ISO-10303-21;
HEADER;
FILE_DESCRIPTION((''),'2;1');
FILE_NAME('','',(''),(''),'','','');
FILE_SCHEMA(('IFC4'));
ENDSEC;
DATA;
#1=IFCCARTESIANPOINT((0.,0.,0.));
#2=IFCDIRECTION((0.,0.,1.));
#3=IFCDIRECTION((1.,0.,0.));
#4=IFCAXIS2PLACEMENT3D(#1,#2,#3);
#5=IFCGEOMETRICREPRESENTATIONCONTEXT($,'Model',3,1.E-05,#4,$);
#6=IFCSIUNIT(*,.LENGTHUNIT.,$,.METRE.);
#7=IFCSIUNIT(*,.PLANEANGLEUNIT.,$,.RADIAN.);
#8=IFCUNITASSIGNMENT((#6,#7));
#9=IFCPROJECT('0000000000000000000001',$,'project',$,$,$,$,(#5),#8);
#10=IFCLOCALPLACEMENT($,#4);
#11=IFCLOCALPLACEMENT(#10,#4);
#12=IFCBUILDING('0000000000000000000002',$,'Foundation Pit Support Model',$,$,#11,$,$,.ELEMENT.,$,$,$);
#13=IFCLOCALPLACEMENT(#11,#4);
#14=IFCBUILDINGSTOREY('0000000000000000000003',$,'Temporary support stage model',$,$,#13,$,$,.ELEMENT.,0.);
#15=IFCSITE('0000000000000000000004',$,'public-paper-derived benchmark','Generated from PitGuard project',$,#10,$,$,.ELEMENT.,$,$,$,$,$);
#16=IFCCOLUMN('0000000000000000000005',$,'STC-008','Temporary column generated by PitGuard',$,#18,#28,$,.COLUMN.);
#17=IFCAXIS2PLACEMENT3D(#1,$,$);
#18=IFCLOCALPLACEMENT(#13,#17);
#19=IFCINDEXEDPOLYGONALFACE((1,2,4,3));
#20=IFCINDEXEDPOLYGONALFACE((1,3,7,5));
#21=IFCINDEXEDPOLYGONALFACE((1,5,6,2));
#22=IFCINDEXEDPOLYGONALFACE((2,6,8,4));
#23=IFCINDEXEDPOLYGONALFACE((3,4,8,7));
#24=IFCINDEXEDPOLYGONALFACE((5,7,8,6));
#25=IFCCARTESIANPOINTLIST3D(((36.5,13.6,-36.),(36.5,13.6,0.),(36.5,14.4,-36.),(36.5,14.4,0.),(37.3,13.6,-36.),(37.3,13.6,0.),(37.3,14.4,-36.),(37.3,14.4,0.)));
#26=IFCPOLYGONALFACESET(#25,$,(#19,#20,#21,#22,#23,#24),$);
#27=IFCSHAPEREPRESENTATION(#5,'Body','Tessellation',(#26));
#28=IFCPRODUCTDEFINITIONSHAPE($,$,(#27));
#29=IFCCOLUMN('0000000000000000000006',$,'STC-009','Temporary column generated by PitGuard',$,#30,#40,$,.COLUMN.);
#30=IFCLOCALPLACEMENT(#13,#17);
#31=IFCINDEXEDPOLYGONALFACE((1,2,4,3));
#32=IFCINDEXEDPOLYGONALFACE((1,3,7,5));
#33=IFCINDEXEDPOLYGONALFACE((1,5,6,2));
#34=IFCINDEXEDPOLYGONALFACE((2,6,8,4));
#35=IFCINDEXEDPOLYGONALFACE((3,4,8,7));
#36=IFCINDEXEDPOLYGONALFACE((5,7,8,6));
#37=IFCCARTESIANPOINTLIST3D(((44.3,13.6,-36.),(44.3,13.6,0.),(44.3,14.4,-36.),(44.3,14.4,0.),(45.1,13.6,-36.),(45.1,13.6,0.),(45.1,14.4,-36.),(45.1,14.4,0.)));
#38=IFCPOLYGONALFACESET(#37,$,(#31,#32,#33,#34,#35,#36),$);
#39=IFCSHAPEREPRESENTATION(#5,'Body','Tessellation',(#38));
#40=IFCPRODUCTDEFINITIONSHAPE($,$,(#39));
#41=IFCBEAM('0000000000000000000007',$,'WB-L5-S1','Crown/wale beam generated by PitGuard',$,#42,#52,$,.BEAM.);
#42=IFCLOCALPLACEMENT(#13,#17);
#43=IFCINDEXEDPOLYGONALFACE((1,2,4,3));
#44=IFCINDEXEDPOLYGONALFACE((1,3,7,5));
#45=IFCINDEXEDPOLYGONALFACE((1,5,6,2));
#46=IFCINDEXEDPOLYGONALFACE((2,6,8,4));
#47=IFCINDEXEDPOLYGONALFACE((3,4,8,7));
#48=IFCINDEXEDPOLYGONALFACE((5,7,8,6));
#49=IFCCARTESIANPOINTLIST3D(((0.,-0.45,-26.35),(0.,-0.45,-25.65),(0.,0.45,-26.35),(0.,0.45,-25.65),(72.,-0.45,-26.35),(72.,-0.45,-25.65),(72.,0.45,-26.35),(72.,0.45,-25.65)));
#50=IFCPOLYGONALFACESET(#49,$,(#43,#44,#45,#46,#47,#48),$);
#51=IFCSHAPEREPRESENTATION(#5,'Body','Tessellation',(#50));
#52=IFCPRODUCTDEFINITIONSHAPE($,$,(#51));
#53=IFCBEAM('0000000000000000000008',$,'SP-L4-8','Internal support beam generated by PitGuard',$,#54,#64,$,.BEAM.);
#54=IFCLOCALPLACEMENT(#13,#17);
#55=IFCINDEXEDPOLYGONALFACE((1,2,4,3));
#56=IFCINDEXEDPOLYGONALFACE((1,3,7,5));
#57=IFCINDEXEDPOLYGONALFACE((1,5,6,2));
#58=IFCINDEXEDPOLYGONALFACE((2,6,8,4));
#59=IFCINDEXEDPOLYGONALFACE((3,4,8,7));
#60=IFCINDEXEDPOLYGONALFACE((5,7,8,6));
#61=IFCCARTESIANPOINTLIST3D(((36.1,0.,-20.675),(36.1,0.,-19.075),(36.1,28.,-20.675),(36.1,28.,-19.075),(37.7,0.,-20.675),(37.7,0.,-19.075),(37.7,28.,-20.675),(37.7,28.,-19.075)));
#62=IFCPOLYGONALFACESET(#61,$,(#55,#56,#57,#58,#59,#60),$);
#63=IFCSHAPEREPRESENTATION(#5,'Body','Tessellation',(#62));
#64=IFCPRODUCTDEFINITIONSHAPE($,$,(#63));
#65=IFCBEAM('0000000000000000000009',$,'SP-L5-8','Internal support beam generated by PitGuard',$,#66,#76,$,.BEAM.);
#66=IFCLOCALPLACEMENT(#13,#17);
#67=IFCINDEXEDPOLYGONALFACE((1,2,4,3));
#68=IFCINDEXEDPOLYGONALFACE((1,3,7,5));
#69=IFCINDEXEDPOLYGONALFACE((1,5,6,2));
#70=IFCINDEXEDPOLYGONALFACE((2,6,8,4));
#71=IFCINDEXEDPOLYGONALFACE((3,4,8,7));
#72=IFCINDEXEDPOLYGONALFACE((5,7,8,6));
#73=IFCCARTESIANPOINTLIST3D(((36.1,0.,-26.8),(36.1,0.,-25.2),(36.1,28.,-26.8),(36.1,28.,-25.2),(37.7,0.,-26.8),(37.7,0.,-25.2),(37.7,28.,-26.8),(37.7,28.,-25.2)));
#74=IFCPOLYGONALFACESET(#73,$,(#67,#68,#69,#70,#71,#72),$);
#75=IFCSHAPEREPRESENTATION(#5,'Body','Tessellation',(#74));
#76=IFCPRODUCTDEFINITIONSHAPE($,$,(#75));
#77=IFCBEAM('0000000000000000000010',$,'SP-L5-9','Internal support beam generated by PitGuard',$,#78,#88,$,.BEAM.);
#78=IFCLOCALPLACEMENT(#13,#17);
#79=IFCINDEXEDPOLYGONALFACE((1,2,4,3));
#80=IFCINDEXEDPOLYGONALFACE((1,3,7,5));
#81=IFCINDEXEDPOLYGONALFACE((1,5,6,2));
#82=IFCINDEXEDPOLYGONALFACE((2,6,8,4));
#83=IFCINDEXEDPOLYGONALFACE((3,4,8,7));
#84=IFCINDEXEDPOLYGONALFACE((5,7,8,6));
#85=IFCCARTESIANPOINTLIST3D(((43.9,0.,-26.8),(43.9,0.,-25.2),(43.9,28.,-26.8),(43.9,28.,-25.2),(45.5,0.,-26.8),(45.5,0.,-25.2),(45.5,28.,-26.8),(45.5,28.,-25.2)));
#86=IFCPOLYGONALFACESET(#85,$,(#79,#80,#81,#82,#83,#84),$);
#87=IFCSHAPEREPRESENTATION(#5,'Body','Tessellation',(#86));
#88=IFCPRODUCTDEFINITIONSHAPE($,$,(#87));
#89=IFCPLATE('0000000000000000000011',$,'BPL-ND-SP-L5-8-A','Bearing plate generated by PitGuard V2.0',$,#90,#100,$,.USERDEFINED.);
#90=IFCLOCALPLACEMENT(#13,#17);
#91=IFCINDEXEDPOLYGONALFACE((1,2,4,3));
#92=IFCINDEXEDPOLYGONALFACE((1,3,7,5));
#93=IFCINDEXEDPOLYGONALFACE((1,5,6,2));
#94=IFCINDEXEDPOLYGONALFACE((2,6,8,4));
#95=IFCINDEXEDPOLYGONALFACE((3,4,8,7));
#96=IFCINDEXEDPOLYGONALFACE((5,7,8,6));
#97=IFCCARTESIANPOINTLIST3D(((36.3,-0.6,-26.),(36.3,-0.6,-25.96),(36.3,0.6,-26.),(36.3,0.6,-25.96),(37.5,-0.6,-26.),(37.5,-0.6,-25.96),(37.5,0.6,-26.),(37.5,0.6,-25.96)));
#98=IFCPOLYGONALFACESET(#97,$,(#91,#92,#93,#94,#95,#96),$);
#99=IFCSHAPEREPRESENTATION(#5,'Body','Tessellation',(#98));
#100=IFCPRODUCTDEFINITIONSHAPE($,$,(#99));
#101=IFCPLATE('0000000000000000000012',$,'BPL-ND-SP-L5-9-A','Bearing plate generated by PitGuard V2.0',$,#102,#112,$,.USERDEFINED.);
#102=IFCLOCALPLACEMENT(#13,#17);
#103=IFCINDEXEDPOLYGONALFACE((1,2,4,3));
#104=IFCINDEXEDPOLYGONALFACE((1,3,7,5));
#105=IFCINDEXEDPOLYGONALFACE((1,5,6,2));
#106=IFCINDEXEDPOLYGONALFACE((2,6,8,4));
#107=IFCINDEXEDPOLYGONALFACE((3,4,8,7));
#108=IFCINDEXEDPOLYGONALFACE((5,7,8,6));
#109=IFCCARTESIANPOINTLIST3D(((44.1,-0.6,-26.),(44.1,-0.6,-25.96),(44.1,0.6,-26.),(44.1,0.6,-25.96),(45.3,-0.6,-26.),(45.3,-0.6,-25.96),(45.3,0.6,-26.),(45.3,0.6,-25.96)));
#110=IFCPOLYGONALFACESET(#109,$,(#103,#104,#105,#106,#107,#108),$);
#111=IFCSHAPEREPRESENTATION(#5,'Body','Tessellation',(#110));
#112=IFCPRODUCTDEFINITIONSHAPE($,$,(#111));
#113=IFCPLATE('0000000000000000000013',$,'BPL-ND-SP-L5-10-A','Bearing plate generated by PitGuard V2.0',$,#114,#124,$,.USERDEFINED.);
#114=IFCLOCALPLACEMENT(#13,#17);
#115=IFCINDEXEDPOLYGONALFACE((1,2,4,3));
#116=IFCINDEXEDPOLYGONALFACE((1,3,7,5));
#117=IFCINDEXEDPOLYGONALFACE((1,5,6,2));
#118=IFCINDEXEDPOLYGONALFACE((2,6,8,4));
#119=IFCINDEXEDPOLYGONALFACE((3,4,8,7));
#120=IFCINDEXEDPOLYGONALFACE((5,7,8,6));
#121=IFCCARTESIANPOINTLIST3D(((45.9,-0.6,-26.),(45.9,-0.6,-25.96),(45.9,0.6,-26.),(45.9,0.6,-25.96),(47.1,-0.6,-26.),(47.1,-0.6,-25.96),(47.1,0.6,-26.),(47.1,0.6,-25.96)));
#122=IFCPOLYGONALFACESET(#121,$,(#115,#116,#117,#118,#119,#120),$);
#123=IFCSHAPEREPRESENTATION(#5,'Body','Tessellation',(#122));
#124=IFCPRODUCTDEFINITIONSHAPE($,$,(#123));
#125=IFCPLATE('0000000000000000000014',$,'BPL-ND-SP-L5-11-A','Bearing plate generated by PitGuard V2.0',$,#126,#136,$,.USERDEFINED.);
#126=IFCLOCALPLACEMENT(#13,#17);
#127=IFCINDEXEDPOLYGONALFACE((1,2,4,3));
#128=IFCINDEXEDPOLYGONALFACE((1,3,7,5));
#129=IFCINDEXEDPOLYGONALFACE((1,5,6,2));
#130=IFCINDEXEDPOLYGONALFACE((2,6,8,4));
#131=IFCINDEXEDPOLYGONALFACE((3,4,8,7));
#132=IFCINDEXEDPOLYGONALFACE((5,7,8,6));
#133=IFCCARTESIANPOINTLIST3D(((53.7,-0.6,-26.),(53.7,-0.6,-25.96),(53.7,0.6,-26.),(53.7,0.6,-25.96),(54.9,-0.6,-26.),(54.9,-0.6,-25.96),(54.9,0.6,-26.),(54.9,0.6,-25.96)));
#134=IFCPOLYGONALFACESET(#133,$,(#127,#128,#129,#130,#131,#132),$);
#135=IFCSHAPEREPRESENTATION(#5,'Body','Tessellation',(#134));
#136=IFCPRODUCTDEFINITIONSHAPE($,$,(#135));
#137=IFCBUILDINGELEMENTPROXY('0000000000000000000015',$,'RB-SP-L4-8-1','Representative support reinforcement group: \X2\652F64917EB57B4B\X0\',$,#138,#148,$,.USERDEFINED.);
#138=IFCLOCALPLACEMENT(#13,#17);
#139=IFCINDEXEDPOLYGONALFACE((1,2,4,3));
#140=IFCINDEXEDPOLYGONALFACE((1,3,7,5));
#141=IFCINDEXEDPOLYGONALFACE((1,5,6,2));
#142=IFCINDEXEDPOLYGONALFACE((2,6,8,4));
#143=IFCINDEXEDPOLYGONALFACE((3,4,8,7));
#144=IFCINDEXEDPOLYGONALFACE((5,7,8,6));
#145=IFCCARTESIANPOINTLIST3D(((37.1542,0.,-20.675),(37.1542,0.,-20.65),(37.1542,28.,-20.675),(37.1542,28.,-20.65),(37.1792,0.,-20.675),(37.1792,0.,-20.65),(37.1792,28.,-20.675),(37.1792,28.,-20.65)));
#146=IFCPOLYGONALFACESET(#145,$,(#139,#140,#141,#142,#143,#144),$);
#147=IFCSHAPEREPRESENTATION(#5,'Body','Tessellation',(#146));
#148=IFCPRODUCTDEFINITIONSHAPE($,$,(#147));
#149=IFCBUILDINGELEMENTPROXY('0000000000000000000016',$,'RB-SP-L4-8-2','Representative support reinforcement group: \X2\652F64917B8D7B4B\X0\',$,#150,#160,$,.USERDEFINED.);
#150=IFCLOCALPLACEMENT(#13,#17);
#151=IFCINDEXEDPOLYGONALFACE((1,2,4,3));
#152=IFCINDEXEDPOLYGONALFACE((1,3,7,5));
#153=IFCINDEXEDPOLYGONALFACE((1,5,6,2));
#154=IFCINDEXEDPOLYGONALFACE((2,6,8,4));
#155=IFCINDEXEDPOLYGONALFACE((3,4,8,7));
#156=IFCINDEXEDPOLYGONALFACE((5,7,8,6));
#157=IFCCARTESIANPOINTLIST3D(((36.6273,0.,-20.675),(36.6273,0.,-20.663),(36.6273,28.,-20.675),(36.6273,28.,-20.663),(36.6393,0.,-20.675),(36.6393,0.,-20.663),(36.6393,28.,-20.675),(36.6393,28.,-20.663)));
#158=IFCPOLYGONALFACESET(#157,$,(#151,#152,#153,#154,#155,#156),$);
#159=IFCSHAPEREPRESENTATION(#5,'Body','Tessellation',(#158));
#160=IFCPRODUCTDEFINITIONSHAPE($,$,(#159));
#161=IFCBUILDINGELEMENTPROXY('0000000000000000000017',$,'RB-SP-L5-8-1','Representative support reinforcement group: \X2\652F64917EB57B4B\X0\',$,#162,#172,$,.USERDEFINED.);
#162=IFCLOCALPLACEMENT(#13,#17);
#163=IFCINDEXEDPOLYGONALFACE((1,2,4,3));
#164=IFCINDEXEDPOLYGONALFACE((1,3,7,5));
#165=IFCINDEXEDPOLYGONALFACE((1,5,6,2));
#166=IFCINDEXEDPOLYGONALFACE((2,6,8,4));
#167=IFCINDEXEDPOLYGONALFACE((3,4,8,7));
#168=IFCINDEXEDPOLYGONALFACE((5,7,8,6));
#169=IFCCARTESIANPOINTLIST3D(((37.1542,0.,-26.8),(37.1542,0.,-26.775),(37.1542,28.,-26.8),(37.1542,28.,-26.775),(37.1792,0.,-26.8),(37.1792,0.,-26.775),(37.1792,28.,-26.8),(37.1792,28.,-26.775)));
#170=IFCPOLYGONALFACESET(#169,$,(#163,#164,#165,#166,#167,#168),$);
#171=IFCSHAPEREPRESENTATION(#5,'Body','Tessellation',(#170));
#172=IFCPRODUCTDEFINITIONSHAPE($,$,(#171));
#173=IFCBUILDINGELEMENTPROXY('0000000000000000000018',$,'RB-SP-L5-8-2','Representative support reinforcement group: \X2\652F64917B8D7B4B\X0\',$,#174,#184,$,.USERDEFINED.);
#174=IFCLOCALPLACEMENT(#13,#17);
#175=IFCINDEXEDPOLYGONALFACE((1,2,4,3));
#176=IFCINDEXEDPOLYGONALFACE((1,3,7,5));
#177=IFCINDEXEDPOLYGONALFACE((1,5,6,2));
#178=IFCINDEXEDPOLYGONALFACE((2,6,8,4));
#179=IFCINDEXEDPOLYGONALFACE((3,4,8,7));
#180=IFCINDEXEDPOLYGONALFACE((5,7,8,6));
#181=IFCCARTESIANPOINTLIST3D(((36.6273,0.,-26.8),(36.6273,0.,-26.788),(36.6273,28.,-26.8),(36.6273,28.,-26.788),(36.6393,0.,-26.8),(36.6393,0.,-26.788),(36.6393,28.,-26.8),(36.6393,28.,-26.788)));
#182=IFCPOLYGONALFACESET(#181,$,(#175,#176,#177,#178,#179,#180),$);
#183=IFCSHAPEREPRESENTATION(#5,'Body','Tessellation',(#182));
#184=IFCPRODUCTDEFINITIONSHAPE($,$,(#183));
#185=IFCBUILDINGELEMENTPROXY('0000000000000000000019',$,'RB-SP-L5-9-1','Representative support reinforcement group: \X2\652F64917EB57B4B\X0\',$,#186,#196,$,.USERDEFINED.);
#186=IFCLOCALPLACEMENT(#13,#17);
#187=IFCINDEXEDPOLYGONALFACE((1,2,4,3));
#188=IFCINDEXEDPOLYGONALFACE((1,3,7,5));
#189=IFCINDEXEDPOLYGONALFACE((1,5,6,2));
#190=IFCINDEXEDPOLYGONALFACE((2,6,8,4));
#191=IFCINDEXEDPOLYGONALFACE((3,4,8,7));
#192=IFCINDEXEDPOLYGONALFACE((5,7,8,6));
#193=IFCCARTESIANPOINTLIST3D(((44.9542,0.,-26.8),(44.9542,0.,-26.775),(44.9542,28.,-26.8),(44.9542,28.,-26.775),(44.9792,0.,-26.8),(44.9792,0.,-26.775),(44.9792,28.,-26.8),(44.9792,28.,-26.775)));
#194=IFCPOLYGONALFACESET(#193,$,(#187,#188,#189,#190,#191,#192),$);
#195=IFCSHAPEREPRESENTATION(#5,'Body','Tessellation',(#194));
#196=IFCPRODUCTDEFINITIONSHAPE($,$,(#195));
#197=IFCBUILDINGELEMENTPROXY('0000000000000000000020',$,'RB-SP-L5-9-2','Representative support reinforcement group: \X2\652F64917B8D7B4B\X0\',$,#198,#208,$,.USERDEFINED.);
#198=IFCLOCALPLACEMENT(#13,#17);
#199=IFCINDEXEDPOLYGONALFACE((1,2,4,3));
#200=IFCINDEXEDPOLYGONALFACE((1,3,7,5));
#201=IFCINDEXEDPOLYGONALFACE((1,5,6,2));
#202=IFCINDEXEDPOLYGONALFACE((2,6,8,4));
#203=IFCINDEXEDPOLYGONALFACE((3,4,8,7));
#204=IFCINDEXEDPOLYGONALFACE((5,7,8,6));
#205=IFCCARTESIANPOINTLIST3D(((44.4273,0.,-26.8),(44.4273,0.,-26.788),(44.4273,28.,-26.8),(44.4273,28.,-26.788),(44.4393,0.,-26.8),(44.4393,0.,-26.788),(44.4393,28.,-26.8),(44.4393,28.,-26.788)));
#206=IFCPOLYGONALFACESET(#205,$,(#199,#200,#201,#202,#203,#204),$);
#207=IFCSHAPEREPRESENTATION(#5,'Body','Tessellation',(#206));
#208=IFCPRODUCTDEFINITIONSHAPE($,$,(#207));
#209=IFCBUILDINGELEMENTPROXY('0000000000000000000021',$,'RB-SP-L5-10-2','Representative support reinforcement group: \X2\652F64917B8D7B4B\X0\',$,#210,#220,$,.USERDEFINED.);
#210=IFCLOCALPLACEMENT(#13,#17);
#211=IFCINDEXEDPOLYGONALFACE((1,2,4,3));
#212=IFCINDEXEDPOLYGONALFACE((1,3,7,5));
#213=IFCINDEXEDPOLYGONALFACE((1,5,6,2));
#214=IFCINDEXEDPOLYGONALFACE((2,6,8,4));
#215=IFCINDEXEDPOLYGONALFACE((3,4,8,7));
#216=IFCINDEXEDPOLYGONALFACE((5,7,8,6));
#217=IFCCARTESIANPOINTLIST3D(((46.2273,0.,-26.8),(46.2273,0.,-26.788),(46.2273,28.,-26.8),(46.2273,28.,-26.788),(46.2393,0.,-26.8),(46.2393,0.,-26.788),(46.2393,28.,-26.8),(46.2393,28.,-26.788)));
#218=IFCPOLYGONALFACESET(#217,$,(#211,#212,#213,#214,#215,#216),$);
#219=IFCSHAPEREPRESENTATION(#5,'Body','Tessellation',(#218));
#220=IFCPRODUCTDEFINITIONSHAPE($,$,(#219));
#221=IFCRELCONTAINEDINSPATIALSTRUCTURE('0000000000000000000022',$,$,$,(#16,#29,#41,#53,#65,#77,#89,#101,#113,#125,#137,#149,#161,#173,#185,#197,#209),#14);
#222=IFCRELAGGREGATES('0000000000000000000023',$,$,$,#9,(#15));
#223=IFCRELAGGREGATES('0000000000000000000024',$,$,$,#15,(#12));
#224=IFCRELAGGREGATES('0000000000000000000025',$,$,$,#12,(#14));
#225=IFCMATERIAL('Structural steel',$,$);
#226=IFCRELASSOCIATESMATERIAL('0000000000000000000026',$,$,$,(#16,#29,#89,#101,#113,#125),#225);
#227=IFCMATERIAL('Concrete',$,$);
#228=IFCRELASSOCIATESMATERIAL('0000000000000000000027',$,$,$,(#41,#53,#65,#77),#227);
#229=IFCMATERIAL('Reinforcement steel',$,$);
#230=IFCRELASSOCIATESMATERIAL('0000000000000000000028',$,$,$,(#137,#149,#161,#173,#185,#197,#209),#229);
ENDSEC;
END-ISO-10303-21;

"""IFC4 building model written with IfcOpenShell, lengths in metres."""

from ifc_helpers import new_model, si_unit, frame, origin_with_axes, origin_2d, place, context, project, spatial, rectangle, extrude, material, element, save


model = new_model("IFC4")

# Units and contexts
model_context = context("Model", 3, precision=1e-05, world=origin_with_axes())
ifc_project = project(units=[si_unit("LENGTHUNIT", "METRE"), si_unit("PLANEANGLEUNIT", "RADIAN")], contexts=[model_context])

# Site, building, storey
site_placement = place(None, origin_with_axes())
site = spatial("IfcSite", under=ifc_project, at=site_placement, Name="public-paper-derived benchmark", Description="Generated from PitGuard project", CompositionType="ELEMENT")
building_placement = place(site_placement, origin_with_axes())
building = spatial("IfcBuilding", under=site, at=building_placement, Name="Foundation Pit Support Model", CompositionType="ELEMENT")
storey_placement = place(building_placement, origin_with_axes())
storey = spatial("IfcBuildingStorey", under=building, at=storey_placement, Name="Temporary support stage model", CompositionType="ELEMENT", Elevation=0.0)

# Columns
ifc_material_1 = material(Name="Structural steel")
for number, where, z_axis, x_axis, name in (
    (1, (36.9, 14.0, -36.0), (0.0, 0.0, 1.0), (1.0, 0.0, 0.0), "STC-008"),
    (2, (44.7, 14.0, -36.0), (0.0, 0.0, 1.0), (1.0, 0.0, 0.0), "STC-009"),
):
    element("IfcColumn", number, at=place(storey_placement, frame(where, z_axis=z_axis, x_axis=x_axis)), inside=storey, material=ifc_material_1, Name=name, Description="Temporary column generated by PitGuard", PredefinedType="COLUMN", context=model_context, shape_type="SweptSolid", body=[
        extrude(rectangle(XDim=0.8, YDim=0.8, at=origin_2d()), origin_with_axes(), (0.0, 0.0, 1.0), 36.0),
    ])

# Beams
ifc_material_2 = material(Name="Concrete")
beam_placement = place(storey_placement, frame((36.0, 0.0, -26.35), z_axis=(0.0, 0.0, 1.0), x_axis=(1.0, 0.0, 0.0)))
element("IfcBeam", 3, at=beam_placement, inside=storey, material=ifc_material_2, Name="WB-L5-S1", Description="Crown/wale beam generated by PitGuard", PredefinedType="BEAM", context=model_context, shape_type="SweptSolid", body=[
    extrude(rectangle(XDim=72.0, YDim=0.9, at=origin_2d()), origin_with_axes(), (0.0, 0.0, 1.0), 0.7),
])
for number, where, z_axis, x_axis, name in (
    (4, (36.9, 14.0, -20.675), (0.0, 0.0, 1.0), (0.0, 1.0, 0.0), "SP-L4-8"),
    (5, (36.9, 14.0, -26.8), (0.0, 0.0, 1.0), (0.0, 1.0, 0.0), "SP-L5-8"),
    (6, (44.7, 14.0, -26.8), (0.0, 0.0, 1.0), (0.0, 1.0, 0.0), "SP-L5-9"),
):
    element("IfcBeam", number, at=place(storey_placement, frame(where, z_axis=z_axis, x_axis=x_axis)), inside=storey, material=ifc_material_2, Name=name, Description="Internal support beam generated by PitGuard", PredefinedType="BEAM", context=model_context, shape_type="SweptSolid", body=[
        extrude(rectangle(XDim=28.0, YDim=1.6, at=origin_2d()), origin_with_axes(), (0.0, 0.0, 1.0), 1.6),
    ])

# Plates
for number, where, z_axis, x_axis, name in (
    (7, (36.9, 0.0, -26.0), (0.0, 0.0, 1.0), (1.0, 0.0, 0.0), "BPL-ND-SP-L5-8-A"),
    (8, (44.7, 0.0, -26.0), (0.0, 0.0, 1.0), (1.0, 0.0, 0.0), "BPL-ND-SP-L5-9-A"),
    (9, (46.5, 0.0, -26.0), (0.0, 0.0, 1.0), (1.0, 0.0, 0.0), "BPL-ND-SP-L5-10-A"),
    (10, (54.3, 0.0, -26.0), (0.0, 0.0, 1.0), (1.0, 0.0, 0.0), "BPL-ND-SP-L5-11-A"),
):
    element("IfcPlate", number, at=place(storey_placement, frame(where, z_axis=z_axis, x_axis=x_axis)), inside=storey, material=ifc_material_1, Name=name, Description="Bearing plate generated by PitGuard V2.0", PredefinedType="USERDEFINED", context=model_context, shape_type="SweptSolid", body=[
        extrude(rectangle(XDim=1.2, YDim=1.2, at=origin_2d()), origin_with_axes(), (0.0, 0.0, 1.0), 0.04),
    ])

# Building element proxies
ifc_material_3 = material(Name="Reinforcement steel")
proxy_1_placement = place(storey_placement, frame((37.1667, 14.0, -20.675), z_axis=(0.0, 0.0, 1.0), x_axis=(0.0, 1.0, 0.0)))
element("IfcBuildingElementProxy", 11, at=proxy_1_placement, inside=storey, material=ifc_material_3, Name="RB-SP-L4-8-1", Description="Representative support reinforcement group: 支撑纵筋", PredefinedType="USERDEFINED", context=model_context, shape_type="SweptSolid", body=[
    extrude(rectangle(XDim=28.0, YDim=0.025, at=origin_2d()), origin_with_axes(), (0.0, 0.0, 1.0), 0.025),
])
proxy_2_placement = place(storey_placement, frame((36.6333, 14.0, -20.675), z_axis=(0.0, 0.0, 1.0), x_axis=(0.0, 1.0, 0.0)))
element("IfcBuildingElementProxy", 12, at=proxy_2_placement, inside=storey, material=ifc_material_3, Name="RB-SP-L4-8-2", Description="Representative support reinforcement group: 支撑箍筋", PredefinedType="USERDEFINED", context=model_context, shape_type="SweptSolid", body=[
    extrude(rectangle(XDim=28.0, YDim=0.012, at=origin_2d()), origin_with_axes(), (0.0, 0.0, 1.0), 0.012),
])
proxy_3_placement = place(storey_placement, frame((37.1667, 14.0, -26.8), z_axis=(0.0, 0.0, 1.0), x_axis=(0.0, 1.0, 0.0)))
element("IfcBuildingElementProxy", 13, at=proxy_3_placement, inside=storey, material=ifc_material_3, Name="RB-SP-L5-8-1", Description="Representative support reinforcement group: 支撑纵筋", PredefinedType="USERDEFINED", context=model_context, shape_type="SweptSolid", body=[
    extrude(rectangle(XDim=28.0, YDim=0.025, at=origin_2d()), origin_with_axes(), (0.0, 0.0, 1.0), 0.025),
])
proxy_4_placement = place(storey_placement, frame((36.6333, 14.0, -26.8), z_axis=(0.0, 0.0, 1.0), x_axis=(0.0, 1.0, 0.0)))
element("IfcBuildingElementProxy", 14, at=proxy_4_placement, inside=storey, material=ifc_material_3, Name="RB-SP-L5-8-2", Description="Representative support reinforcement group: 支撑箍筋", PredefinedType="USERDEFINED", context=model_context, shape_type="SweptSolid", body=[
    extrude(rectangle(XDim=28.0, YDim=0.012, at=origin_2d()), origin_with_axes(), (0.0, 0.0, 1.0), 0.012),
])
proxy_5_placement = place(storey_placement, frame((44.9667, 14.0, -26.8), z_axis=(0.0, 0.0, 1.0), x_axis=(0.0, 1.0, 0.0)))
element("IfcBuildingElementProxy", 15, at=proxy_5_placement, inside=storey, material=ifc_material_3, Name="RB-SP-L5-9-1", Description="Representative support reinforcement group: 支撑纵筋", PredefinedType="USERDEFINED", context=model_context, shape_type="SweptSolid", body=[
    extrude(rectangle(XDim=28.0, YDim=0.025, at=origin_2d()), origin_with_axes(), (0.0, 0.0, 1.0), 0.025),
])
for number, where, z_axis, x_axis, name in (
    (16, (44.4333, 14.0, -26.8), (0.0, 0.0, 1.0), (0.0, 1.0, 0.0), "RB-SP-L5-9-2"),
    (17, (46.2333, 14.0, -26.8), (0.0, 0.0, 1.0), (0.0, 1.0, 0.0), "RB-SP-L5-10-2"),
):
    element("IfcBuildingElementProxy", number, at=place(storey_placement, frame(where, z_axis=z_axis, x_axis=x_axis)), inside=storey, material=ifc_material_3, Name=name, Description="Representative support reinforcement group: 支撑箍筋", PredefinedType="USERDEFINED", context=model_context, shape_type="SweptSolid", body=[
        extrude(rectangle(XDim=28.0, YDim=0.012, at=origin_2d()), origin_with_axes(), (0.0, 0.0, 1.0), 0.012),
    ])

save(model, "model.ifc")
